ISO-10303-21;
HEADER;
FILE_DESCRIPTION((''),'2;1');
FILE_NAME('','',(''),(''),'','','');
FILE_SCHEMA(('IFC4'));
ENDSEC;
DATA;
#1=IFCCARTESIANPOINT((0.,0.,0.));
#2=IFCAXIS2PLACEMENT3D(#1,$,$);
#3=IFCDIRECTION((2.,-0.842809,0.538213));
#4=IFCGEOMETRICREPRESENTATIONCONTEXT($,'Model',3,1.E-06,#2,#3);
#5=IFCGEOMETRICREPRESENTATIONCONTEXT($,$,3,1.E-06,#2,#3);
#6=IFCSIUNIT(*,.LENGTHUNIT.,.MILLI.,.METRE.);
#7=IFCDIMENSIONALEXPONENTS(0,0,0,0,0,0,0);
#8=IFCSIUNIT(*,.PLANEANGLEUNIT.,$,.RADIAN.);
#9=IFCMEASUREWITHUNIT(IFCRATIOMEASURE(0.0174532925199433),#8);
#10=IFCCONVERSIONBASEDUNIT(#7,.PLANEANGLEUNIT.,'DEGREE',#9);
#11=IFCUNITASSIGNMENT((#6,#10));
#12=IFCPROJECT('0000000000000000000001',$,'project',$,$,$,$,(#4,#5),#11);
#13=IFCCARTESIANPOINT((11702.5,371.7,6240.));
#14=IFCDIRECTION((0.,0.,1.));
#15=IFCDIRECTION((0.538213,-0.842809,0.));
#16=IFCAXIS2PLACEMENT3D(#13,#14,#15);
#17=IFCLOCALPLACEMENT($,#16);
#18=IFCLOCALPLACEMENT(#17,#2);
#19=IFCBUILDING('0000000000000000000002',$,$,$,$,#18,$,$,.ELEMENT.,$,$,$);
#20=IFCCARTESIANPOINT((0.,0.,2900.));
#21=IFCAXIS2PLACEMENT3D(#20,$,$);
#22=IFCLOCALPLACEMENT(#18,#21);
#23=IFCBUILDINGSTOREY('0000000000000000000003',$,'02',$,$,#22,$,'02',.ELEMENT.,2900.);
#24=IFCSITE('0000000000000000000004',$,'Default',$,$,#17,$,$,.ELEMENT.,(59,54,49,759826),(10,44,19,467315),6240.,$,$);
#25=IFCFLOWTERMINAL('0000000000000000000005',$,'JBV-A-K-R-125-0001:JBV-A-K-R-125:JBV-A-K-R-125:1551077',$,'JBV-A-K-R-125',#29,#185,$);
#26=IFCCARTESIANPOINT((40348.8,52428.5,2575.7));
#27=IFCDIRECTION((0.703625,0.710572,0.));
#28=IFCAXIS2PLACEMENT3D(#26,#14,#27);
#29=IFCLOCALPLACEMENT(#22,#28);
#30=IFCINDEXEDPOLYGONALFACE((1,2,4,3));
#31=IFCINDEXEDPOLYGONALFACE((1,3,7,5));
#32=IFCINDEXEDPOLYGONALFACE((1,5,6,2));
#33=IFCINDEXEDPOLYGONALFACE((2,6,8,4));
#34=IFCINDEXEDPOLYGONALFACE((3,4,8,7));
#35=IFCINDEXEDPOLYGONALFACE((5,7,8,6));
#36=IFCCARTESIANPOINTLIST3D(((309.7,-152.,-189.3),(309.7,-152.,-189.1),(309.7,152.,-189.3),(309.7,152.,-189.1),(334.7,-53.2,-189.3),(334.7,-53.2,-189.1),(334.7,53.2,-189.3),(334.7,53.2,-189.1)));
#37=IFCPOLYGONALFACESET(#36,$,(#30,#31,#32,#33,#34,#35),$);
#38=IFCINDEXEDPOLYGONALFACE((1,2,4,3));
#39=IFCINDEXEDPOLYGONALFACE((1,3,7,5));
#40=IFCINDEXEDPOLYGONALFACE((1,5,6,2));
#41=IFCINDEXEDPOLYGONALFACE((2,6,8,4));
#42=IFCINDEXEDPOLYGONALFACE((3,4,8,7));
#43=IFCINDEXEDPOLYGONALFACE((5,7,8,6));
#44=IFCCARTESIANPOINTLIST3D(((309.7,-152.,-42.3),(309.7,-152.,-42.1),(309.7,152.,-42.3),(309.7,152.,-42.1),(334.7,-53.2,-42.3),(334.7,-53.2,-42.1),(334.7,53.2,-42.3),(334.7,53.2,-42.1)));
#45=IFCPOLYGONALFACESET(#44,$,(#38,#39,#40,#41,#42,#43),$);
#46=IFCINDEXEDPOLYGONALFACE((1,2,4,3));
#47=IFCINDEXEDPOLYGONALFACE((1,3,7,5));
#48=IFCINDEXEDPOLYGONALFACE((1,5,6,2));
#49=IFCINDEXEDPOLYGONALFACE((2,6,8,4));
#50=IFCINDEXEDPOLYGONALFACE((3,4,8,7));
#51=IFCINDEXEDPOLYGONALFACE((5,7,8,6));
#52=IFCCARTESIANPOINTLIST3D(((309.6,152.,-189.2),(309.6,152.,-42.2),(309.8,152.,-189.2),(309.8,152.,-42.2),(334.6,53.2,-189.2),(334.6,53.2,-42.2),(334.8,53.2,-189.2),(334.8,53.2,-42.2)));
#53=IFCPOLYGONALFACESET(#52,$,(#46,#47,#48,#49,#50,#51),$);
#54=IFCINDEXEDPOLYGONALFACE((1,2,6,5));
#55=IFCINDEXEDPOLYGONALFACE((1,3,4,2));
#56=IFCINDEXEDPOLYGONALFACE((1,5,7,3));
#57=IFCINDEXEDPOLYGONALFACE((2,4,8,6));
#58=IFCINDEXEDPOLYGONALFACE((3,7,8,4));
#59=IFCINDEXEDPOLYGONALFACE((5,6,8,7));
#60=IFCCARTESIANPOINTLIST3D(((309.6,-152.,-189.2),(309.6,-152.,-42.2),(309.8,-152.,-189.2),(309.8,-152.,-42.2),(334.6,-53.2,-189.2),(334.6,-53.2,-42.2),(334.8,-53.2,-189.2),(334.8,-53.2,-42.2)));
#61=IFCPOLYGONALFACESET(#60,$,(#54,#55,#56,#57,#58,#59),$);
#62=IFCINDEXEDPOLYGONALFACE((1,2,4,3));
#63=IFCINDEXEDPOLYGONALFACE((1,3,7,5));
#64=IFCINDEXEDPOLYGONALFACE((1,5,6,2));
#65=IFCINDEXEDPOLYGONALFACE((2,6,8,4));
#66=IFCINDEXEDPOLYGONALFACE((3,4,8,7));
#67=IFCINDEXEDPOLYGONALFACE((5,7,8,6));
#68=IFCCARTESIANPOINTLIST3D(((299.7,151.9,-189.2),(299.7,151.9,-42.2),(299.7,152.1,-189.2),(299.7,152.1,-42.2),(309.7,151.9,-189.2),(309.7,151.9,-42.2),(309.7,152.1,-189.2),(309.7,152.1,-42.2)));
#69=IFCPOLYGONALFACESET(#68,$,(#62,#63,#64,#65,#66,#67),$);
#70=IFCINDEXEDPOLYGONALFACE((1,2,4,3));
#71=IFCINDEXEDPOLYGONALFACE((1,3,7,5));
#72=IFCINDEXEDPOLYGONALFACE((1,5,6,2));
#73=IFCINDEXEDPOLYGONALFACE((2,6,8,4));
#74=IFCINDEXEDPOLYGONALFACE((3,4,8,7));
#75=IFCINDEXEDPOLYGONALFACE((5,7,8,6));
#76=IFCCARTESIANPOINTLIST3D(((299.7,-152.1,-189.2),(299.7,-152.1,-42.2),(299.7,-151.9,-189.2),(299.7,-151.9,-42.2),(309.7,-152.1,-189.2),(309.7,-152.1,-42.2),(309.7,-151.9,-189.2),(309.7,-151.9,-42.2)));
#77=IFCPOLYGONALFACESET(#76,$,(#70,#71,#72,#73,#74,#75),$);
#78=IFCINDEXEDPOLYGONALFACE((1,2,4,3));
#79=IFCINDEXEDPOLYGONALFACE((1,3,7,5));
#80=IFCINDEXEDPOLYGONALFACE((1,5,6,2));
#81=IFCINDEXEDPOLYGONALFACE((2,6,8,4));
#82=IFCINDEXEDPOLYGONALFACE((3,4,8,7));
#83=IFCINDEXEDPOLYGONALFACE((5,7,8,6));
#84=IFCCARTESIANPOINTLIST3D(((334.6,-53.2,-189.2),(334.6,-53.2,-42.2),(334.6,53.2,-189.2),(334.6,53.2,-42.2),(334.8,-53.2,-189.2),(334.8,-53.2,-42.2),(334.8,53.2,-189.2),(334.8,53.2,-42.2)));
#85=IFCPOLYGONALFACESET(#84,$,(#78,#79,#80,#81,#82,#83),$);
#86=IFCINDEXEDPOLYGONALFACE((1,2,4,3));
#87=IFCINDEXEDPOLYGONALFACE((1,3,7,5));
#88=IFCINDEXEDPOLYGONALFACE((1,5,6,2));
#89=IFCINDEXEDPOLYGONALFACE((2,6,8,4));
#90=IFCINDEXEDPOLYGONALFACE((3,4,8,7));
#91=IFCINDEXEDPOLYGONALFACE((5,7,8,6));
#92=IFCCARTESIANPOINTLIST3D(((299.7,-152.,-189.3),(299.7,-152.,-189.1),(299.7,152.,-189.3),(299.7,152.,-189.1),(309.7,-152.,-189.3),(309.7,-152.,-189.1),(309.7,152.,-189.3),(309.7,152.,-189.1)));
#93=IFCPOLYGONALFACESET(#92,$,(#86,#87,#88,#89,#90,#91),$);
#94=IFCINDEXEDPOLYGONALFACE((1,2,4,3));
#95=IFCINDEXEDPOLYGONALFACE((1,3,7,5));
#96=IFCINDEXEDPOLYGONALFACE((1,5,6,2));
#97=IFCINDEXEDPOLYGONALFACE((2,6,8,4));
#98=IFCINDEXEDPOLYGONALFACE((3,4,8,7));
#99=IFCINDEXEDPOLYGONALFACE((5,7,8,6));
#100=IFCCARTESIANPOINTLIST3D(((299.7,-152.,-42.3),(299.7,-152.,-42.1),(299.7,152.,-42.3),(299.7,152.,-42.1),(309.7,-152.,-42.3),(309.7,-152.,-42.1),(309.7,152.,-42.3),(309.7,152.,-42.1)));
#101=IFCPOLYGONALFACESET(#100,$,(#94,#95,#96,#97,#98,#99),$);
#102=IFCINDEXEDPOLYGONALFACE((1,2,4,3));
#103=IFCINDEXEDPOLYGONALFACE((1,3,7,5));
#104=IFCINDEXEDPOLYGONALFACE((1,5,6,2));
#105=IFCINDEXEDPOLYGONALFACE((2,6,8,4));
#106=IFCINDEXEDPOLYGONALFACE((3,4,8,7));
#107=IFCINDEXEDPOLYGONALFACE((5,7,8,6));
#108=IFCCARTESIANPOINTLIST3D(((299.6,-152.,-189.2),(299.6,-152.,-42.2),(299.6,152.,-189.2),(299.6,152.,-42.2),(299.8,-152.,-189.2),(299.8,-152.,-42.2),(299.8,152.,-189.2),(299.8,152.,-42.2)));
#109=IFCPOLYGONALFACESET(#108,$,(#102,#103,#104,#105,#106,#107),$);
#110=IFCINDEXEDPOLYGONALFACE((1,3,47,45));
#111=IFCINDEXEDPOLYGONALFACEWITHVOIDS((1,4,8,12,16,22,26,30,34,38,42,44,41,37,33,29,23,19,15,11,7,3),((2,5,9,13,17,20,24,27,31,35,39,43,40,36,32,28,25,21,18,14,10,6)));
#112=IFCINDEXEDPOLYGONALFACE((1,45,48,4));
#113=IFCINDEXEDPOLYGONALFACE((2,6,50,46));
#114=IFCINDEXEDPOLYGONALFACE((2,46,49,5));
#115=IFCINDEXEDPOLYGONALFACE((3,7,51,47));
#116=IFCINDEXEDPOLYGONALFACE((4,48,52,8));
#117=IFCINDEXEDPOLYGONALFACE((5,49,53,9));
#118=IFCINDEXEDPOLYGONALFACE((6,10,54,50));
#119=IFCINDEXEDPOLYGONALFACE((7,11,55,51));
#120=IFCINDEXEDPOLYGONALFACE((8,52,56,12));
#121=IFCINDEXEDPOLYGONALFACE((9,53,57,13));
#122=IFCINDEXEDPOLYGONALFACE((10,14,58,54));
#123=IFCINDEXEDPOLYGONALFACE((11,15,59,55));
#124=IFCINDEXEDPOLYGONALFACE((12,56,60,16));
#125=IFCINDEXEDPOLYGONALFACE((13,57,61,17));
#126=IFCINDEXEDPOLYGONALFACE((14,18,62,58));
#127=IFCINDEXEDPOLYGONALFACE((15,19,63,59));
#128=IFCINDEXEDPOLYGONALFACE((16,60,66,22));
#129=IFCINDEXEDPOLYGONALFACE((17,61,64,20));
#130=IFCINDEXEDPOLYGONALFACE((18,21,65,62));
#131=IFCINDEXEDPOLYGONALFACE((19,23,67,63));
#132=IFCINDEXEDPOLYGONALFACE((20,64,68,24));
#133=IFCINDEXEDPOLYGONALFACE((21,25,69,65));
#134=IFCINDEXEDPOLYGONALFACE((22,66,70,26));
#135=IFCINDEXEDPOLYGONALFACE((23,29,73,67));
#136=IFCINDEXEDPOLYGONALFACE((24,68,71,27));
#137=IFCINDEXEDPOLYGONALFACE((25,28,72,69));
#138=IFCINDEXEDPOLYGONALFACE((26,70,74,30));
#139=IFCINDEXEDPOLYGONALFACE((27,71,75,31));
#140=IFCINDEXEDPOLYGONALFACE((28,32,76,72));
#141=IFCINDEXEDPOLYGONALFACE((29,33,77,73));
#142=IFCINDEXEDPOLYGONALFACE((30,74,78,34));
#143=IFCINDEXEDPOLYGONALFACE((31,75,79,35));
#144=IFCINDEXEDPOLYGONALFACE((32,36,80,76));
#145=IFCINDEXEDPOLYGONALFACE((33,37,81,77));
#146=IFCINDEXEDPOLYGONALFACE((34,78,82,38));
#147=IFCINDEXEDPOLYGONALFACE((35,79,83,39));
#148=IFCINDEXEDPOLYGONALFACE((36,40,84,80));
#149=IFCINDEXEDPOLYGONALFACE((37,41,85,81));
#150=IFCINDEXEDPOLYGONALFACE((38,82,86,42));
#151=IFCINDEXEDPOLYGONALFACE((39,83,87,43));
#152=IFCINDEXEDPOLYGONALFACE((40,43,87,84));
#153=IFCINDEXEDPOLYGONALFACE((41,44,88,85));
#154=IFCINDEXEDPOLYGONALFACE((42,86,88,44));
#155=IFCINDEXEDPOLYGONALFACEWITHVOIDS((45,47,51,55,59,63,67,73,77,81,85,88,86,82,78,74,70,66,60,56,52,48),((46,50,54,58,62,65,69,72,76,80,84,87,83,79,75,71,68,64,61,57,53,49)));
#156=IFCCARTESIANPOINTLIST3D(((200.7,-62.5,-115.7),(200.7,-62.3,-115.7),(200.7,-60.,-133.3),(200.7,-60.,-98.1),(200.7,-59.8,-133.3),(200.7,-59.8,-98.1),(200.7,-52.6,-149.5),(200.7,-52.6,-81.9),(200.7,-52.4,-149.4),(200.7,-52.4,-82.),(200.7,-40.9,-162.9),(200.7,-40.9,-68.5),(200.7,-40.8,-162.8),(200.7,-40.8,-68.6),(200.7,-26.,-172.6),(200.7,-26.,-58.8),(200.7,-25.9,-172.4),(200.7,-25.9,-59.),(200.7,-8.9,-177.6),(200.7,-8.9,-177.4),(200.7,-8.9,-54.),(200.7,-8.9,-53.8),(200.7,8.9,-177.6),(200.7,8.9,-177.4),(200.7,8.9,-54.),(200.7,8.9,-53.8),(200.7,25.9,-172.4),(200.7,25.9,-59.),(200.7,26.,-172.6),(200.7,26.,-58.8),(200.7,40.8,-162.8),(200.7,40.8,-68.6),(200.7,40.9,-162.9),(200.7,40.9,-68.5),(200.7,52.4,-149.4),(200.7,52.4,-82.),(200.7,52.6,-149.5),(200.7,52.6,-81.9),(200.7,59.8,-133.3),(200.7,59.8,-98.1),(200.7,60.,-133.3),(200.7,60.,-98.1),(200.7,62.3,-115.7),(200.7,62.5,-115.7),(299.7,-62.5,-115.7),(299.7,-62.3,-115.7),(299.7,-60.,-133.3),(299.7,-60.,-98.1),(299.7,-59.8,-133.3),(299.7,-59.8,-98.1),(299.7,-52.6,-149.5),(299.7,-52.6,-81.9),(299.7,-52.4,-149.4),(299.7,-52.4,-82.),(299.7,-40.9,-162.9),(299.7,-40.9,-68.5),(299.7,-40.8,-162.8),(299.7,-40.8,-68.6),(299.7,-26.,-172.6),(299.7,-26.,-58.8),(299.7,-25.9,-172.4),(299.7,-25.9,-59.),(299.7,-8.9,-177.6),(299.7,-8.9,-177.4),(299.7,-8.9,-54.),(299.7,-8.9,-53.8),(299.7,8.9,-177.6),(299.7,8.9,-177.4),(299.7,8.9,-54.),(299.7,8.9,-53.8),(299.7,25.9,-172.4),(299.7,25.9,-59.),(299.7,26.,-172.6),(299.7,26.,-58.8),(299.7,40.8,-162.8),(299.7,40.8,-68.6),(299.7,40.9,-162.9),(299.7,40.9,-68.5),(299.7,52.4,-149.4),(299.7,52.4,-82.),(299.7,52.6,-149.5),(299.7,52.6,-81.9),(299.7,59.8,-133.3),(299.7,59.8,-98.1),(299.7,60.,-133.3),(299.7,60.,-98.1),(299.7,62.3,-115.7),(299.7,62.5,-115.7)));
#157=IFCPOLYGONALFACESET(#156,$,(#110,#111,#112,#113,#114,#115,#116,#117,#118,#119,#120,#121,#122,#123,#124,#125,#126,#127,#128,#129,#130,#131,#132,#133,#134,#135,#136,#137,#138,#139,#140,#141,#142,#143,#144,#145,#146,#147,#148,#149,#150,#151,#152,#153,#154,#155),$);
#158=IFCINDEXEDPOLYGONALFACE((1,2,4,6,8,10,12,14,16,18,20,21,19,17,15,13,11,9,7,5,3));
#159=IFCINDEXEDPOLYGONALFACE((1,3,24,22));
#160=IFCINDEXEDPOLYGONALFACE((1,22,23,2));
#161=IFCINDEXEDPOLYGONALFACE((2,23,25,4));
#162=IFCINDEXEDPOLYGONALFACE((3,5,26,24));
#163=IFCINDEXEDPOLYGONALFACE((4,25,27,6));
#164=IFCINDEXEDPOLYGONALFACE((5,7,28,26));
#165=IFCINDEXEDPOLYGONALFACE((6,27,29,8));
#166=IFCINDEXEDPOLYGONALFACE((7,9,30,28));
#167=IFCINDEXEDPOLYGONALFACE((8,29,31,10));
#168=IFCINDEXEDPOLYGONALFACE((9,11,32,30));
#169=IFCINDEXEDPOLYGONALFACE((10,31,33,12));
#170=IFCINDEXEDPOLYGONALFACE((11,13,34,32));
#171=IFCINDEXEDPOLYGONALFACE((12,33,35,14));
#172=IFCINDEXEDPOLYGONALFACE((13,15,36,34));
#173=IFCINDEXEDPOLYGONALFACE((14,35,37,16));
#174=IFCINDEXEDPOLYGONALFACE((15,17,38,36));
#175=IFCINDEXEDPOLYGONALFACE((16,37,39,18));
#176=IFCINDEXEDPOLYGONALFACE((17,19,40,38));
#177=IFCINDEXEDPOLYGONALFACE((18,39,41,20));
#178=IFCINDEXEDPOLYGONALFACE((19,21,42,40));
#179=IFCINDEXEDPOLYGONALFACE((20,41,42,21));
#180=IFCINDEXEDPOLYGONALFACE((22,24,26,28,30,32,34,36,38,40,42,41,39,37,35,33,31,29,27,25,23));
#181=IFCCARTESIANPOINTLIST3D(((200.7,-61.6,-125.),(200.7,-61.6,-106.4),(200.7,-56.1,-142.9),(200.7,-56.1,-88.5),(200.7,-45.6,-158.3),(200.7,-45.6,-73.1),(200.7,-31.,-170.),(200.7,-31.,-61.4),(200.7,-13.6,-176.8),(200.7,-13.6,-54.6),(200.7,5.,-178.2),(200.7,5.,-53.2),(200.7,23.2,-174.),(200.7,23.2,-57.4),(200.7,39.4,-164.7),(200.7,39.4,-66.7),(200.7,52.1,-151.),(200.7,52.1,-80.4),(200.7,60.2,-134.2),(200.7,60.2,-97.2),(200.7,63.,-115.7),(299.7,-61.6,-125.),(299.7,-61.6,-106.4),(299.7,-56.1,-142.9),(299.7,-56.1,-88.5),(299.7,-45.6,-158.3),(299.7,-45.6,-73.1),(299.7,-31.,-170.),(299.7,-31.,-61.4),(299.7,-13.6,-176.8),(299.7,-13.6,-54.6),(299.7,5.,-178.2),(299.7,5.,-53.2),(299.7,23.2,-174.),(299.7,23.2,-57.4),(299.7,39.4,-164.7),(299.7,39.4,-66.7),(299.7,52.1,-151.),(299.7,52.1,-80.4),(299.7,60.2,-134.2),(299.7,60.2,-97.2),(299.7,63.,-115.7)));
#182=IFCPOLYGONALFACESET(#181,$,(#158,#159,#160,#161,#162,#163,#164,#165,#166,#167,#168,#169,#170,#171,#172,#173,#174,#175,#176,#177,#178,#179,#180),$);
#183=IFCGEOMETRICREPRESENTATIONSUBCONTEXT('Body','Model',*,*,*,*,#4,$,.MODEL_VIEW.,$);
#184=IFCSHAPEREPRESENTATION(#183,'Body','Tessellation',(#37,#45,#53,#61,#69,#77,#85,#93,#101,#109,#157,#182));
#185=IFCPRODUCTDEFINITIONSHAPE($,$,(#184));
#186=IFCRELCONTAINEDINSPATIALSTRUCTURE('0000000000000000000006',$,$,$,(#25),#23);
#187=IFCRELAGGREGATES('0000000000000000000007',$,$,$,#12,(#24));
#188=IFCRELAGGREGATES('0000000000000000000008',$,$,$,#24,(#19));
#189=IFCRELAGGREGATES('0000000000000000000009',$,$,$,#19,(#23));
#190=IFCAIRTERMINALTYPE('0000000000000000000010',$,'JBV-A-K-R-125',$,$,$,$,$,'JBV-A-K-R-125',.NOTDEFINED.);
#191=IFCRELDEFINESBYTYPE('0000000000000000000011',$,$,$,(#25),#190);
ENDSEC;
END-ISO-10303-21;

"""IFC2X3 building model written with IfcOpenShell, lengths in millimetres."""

from ifc_helpers import new_model, entity, si_unit, converted_unit, direction, frame, frame_2d, origin, origin_2d_with_axis, place, context, subcontext, project, spatial, polyline, circle_curve, parameter, trimmed, segment, composite_curve, rectangle, circle, outline, extrude, source, transform, mapped, type_object, type_shapes, element, save


model = new_model("IFC2X3")

# Units and contexts
model_context = context("Model", 3, precision=1e-06, world=origin(), true_north=direction((2.0, -0.842809, 0.538213)))
context_of_model = context(None, 3, precision=1e-06, world=origin(), true_north=direction((2.0, -0.842809, 0.538213)))
body_context = subcontext(model_context, "Body", "Model", "MODEL_VIEW")
ifc_project = project(units=[si_unit("LENGTHUNIT", "METRE", prefix="MILLI"), converted_unit("PLANEANGLEUNIT", "DEGREE", entity("IfcRatioMeasure", 0.0174532925199433), si_unit("PLANEANGLEUNIT", "RADIAN"), dimensions=[0, 0, 0, 0, 0, 0, 0])], contexts=[model_context, context_of_model])

# Site, building, storey
site_placement = place(None, frame((11702.5, 371.7, 6240.0), z_axis=(0.0, 0.0, 1.0), x_axis=(0.538213, -0.842809, 0.0)))
site = spatial("IfcSite", under=ifc_project, at=site_placement, Name="Default", CompositionType="ELEMENT", RefLatitude=(59, 54, 49, 759826), RefLongitude=(10, 44, 19, 467315), RefElevation=6240.0)
building_placement = place(site_placement, origin())
building = spatial("IfcBuilding", under=site, at=building_placement, CompositionType="ELEMENT")
storey_placement = place(building_placement, frame((0.0, 0.0, 2900.0)))
storey = spatial("IfcBuildingStorey", under=building, at=storey_placement, Name="02", LongName="02", CompositionType="ELEMENT", Elevation=2900.0)

# Flow terminal
air_terminal_type_1 = type_object("IfcAirTerminalType", Name="JBV-A-K-R-125", ElementType="JBV-A-K-R-125", PredefinedType="NOTDEFINED")
shared_shape_1 = source(origin(), body_context, "Body", "SweptSolid", [
    extrude(outline(polyline([(-152.0, -12.5), (152.0, -12.5), (53.2, 12.5), (-53.2, 12.5), (-152.0, -12.5)])), frame((322.2, 0.0, -189.3), z_axis=(0.0, 0.0, 1.0), x_axis=(0.0, -1.0, 0.0)), (0.0, 0.0, 1.0), 0.2),
    extrude(outline(polyline([(-152.0, -12.5), (152.0, -12.5), (53.2, 12.5), (-53.2, 12.5), (-152.0, -12.5)])), frame((322.2, 0.0, -42.3), z_axis=(0.0, 0.0, 1.0), x_axis=(0.0, -1.0, 0.0)), (0.0, 0.0, 1.0), 0.2),
    extrude(rectangle(XDim=0.2, YDim=101.9, at=frame_2d((0.0, 0.0), x_axis=(1.0, 0.0))), frame((322.2, 102.6, -189.2), z_axis=(0.0, 0.0, 1.0), x_axis=(0.969446, 0.245305, 0.0)), (0.0, 0.0, 1.0), 147.0),
    extrude(rectangle(XDim=0.2, YDim=101.9, at=frame_2d((0.0, 0.0), x_axis=(1.0, 0.0))), frame((322.2, -102.6, -189.2), z_axis=(0.0, 0.0, 1.0), x_axis=(-0.969446, 0.245305, 0.0)), (0.0, 0.0, 1.0), 147.0),
    extrude(rectangle(XDim=0.2, YDim=10.0, at=frame_2d((0.0, 0.0), x_axis=(1.0, 0.0))), frame((304.7, 152.0, -189.2), z_axis=(0.0, 0.0, 1.0), x_axis=(0.0, 1.0, 0.0)), (0.0, 0.0, 1.0), 147.0),
    extrude(rectangle(XDim=0.2, YDim=10.0, at=frame_2d((0.0, 0.0), x_axis=(1.0, 0.0))), frame((304.7, -152.0, -189.2), z_axis=(0.0, 0.0, 1.0), x_axis=(0.0, 1.0, 0.0)), (0.0, 0.0, 1.0), 147.0),
    extrude(rectangle(XDim=0.2, YDim=106.4, at=frame_2d((0.0, 0.0), x_axis=(1.0, 0.0))), frame((334.7, 0.0, -189.2)), (0.0, 0.0, 1.0), 147.0),
    extrude(rectangle(XDim=304.0, YDim=10.0, at=frame_2d((0.0, 0.0), x_axis=(1.0, 0.0))), frame((304.7, 0.0, -189.3), z_axis=(0.0, 0.0, 1.0), x_axis=(0.0, -1.0, 0.0)), (0.0, 0.0, 1.0), 0.2),
    extrude(rectangle(XDim=304.0, YDim=10.0, at=frame_2d((0.0, 0.0), x_axis=(1.0, 0.0))), frame((304.7, 0.0, -42.3), z_axis=(0.0, 0.0, 1.0), x_axis=(0.0, -1.0, 0.0)), (0.0, 0.0, 1.0), 0.2),
    extrude(rectangle(XDim=0.2, YDim=304.0, at=frame_2d((0.0, 0.0), x_axis=(1.0, 0.0))), frame((299.7, 0.0, -189.2)), (0.0, 0.0, 1.0), 147.0),
    extrude(outline(composite_curve([segment(trimmed(circle_curve(origin_2d_with_axis(), 62.5), [parameter(0.0)], [parameter(180.0)], True, "PARAMETER"), True, "CONTINUOUS"), segment(trimmed(circle_curve(origin_2d_with_axis(), 62.5), [parameter(180.0)], [parameter(360.0)], True, "PARAMETER"), True, "CONTINUOUS")], self_intersect=False), holes=[composite_curve([segment(trimmed(circle_curve(origin_2d_with_axis(), 62.3), [parameter(180.0)], [parameter(360.0)], True, "PARAMETER"), False, "CONTINUOUS"), segment(trimmed(circle_curve(origin_2d_with_axis(), 62.3), [parameter(0.0)], [parameter(180.0)], True, "PARAMETER"), False, "CONTINUOUS")], self_intersect=False)]), frame((200.7, 0.0, -115.7), z_axis=(1.0, 0.0, 0.0), x_axis=(0.0, 1.0, 0.0)), (0.0, 0.0, 1.0), 99.0),
    extrude(circle(Radius=62.6, at=frame_2d((0.0, 0.0), x_axis=(1.0, 0.0))), frame((200.7, 0.3, -115.7), z_axis=(1.0, 0.0, 0.0), x_axis=(0.0, 1.0, 0.0)), (0.0, 0.0, 1.0), 99.0),
])
type_shapes(air_terminal_type_1, [shared_shape_1])
for number, where, z_axis, x_axis, name in (
    (1, (40348.8, 52428.5, 2575.7), (0.0, 0.0, 1.0), (0.703625, 0.710572, 0.0), "JBV-A-K-R-125-0001:JBV-A-K-R-125:JBV-A-K-R-125:1551077"),
):
    element("IfcFlowTerminal", number, at=place(storey_placement, frame(where, z_axis=z_axis, x_axis=x_axis)), inside=storey, type_object=air_terminal_type_1, Name=name, ObjectType="JBV-A-K-R-125", context=body_context, shape_type="MappedRepresentation", body=[
        mapped(shared_shape_1, transform((0.0, 0.0, 0.0), scale=1.0)),
    ])

save(model, "model.ifc")
